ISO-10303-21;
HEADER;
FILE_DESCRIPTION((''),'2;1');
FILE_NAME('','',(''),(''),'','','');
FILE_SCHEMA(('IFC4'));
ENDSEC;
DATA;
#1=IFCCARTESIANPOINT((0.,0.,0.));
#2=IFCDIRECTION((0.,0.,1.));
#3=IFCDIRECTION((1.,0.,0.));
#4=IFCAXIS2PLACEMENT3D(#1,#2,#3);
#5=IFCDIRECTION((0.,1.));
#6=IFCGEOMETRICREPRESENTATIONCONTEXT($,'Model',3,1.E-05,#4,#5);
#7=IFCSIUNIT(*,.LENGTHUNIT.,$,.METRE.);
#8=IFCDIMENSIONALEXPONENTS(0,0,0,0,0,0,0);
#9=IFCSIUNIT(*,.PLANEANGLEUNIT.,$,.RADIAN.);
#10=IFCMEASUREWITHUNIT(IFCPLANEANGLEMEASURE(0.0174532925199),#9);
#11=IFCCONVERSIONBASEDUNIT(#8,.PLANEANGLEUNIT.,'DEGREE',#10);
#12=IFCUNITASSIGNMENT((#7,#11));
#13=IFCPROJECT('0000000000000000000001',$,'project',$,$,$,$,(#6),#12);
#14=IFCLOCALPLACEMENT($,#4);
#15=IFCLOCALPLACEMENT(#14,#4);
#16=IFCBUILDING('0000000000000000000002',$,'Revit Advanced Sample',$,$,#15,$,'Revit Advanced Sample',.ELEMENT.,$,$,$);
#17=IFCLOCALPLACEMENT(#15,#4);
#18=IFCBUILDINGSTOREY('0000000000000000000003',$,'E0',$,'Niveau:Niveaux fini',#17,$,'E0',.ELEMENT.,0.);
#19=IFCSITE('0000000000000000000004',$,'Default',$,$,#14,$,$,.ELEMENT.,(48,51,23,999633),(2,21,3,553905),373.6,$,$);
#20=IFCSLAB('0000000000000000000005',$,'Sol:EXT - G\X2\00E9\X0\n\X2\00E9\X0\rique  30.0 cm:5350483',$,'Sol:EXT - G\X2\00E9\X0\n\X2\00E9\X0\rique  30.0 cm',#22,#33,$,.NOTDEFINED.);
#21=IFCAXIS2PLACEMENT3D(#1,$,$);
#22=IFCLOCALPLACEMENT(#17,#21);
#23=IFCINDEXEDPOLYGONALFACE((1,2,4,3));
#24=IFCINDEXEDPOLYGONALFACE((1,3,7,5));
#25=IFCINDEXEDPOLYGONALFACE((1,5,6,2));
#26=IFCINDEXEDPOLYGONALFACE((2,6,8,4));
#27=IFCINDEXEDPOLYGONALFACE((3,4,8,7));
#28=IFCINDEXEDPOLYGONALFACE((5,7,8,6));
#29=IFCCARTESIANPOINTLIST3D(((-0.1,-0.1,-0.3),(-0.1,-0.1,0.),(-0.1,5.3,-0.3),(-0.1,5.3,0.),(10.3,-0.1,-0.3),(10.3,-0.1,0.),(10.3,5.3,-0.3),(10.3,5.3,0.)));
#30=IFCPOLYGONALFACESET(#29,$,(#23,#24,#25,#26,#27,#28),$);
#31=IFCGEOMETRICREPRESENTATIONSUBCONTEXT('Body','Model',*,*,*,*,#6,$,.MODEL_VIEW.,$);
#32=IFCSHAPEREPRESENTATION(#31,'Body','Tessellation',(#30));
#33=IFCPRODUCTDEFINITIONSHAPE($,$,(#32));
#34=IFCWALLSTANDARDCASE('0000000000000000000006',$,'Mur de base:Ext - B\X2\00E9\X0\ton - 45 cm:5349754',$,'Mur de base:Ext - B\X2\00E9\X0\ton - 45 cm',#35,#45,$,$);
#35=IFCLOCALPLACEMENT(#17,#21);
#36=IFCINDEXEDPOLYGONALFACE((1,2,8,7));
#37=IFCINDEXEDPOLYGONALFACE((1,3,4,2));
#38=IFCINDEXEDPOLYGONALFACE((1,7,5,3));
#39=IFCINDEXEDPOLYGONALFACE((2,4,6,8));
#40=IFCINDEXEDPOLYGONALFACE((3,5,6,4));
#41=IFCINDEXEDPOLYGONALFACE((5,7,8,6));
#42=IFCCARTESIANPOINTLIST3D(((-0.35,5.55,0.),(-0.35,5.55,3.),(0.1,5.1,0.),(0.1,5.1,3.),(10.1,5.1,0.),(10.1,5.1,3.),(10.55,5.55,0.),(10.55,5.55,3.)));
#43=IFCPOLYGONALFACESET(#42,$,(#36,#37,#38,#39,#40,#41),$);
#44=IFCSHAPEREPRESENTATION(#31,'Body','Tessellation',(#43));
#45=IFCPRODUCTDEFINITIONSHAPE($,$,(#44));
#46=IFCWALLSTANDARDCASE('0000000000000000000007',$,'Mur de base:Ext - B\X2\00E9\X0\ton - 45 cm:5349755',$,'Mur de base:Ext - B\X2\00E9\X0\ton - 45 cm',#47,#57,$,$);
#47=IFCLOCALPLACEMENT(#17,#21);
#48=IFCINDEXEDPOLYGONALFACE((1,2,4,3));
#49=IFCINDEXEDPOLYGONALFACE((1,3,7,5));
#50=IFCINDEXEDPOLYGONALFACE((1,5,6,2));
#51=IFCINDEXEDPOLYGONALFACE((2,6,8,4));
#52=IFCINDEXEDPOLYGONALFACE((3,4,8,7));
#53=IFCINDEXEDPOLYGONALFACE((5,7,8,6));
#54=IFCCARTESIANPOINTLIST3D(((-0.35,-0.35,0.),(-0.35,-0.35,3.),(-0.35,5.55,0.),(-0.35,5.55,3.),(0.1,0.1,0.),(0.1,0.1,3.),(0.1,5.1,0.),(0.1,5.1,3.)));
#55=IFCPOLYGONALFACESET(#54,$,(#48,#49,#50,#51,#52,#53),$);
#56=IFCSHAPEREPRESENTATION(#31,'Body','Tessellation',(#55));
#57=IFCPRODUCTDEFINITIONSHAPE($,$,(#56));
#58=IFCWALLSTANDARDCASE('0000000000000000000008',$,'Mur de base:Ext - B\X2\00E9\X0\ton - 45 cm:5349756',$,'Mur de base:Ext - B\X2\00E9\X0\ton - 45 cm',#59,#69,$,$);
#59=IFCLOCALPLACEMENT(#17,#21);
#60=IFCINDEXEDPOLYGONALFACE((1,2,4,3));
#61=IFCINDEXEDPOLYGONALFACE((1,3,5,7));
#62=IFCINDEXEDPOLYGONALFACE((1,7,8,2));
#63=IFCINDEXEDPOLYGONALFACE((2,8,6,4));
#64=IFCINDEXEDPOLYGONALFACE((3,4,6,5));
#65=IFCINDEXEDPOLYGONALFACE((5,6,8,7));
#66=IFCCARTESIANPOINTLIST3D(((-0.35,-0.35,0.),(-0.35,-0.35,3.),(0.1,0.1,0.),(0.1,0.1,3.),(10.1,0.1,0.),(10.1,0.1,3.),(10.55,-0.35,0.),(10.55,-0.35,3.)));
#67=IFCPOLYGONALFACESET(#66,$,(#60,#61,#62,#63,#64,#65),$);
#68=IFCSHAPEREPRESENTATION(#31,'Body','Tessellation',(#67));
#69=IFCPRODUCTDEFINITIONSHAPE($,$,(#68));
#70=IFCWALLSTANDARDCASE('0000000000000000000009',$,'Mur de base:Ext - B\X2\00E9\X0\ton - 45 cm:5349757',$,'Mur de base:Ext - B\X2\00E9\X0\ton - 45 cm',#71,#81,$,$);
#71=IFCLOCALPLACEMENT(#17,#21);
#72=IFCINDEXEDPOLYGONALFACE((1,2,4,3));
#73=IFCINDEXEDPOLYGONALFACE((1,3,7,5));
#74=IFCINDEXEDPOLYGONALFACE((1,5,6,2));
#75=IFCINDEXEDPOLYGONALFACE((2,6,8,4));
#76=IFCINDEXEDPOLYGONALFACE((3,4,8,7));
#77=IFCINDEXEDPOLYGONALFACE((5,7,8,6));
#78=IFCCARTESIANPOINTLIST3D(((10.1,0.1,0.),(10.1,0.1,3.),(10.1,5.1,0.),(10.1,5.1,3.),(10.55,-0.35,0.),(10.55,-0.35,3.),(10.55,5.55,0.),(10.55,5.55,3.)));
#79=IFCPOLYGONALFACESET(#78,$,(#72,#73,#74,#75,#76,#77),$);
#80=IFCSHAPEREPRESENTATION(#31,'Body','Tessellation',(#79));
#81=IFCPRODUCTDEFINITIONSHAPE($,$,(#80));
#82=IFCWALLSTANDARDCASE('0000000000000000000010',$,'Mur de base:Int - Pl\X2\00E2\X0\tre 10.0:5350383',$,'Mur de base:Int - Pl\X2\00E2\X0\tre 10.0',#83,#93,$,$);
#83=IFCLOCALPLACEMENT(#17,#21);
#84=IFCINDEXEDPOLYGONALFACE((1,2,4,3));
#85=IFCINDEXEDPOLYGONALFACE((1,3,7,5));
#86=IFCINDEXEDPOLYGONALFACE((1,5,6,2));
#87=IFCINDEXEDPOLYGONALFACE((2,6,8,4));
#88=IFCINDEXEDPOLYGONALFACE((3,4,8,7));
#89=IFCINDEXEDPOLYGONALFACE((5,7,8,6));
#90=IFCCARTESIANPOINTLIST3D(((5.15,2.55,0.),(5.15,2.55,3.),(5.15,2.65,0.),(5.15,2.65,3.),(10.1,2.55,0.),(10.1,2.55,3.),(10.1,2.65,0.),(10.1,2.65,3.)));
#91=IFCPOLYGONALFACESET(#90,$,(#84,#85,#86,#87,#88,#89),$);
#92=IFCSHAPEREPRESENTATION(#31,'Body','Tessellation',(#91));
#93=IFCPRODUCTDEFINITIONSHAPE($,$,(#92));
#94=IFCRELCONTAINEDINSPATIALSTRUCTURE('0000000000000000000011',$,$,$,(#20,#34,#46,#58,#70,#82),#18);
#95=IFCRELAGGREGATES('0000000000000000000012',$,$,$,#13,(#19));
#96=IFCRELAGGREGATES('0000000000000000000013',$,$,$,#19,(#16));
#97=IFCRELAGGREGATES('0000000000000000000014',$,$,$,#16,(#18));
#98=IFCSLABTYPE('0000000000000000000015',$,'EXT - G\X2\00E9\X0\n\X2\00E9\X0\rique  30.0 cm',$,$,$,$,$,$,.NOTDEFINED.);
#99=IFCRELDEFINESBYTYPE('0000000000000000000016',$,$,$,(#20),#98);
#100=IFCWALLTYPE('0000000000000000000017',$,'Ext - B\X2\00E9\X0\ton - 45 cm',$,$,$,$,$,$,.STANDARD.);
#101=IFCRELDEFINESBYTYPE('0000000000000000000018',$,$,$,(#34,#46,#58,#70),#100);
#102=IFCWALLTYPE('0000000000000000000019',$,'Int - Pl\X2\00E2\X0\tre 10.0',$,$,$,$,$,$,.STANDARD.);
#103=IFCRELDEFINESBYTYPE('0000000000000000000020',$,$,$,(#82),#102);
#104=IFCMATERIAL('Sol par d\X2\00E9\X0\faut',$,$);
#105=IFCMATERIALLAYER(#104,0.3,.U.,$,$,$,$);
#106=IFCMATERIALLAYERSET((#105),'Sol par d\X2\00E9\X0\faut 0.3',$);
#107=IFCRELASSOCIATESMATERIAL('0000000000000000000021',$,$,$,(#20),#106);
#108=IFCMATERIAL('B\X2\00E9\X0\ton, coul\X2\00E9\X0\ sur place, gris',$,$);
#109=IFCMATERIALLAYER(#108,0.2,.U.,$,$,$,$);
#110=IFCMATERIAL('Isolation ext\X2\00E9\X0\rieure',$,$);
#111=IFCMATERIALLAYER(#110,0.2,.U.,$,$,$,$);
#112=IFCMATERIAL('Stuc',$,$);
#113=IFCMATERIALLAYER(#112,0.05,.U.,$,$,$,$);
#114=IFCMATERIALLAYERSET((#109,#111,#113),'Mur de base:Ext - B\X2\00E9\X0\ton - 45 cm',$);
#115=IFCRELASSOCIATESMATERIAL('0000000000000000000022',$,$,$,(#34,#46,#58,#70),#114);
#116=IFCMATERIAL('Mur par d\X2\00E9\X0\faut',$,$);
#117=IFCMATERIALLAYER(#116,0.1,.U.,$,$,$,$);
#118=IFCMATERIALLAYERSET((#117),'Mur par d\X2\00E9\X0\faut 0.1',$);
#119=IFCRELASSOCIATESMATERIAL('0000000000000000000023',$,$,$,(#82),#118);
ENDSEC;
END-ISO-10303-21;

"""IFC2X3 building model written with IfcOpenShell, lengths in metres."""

from ifc_helpers import new_model, entity, si_unit, converted_unit, direction, frame, origin_with_axes, place, context, subcontext, project, spatial, polyline, outline, extrude, material, layer, layer_set, layer_usage, type_object, element, save


model = new_model("IFC2X3")

# Units and contexts
model_context = context("Model", 3, precision=1e-05, world=origin_with_axes(), true_north=direction((0.0, 1.0)))
body_context = subcontext(model_context, "Body", "Model", "MODEL_VIEW")
ifc_project = project(units=[si_unit("LENGTHUNIT", "METRE"), converted_unit("PLANEANGLEUNIT", "DEGREE", entity("IfcPlaneAngleMeasure", 0.0174532925199), si_unit("PLANEANGLEUNIT", "RADIAN"), dimensions=[0, 0, 0, 0, 0, 0, 0])], contexts=[model_context])

# Site, building, storey
site_placement = place(None, origin_with_axes())
site = spatial("IfcSite", under=ifc_project, at=site_placement, Name="Default", CompositionType="ELEMENT", RefLatitude=(48, 51, 23, 999633), RefLongitude=(2, 21, 3, 553905), RefElevation=373.6)
building_placement = place(site_placement, origin_with_axes())
building = spatial("IfcBuilding", under=site, at=building_placement, Name="Revit Advanced Sample", LongName="Revit Advanced Sample", CompositionType="ELEMENT")
storey_placement = place(building_placement, origin_with_axes())
storey = spatial("IfcBuildingStorey", under=building, at=storey_placement, Name="E0", ObjectType="Niveau:Niveaux fini", LongName="E0", CompositionType="ELEMENT", Elevation=0.0)

# Slab
ifc_material_1 = material(Name="Sol par défaut")
ifc_layer_1 = layer(ifc_material_1, 0.3, ventilated="UNKNOWN")
ifc_layer_set_1 = layer_set([ifc_layer_1], Name="Sol par défaut 0.3")
ifc_layer_usage_1 = layer_usage(ifc_layer_set_1, "AXIS3", "NEGATIVE", 0.3)
slab_type = type_object("IfcSlabType", Name="EXT - Générique  30.0 cm", PredefinedType="NOTDEFINED")
slab_placement = place(storey_placement, frame((-0.1, 5.3, 0.0), z_axis=(0.0, 0.0, 1.0), x_axis=(1.0, 0.0, 0.0)))
element("IfcSlab", 1, at=slab_placement, inside=storey, type_object=slab_type, material=ifc_layer_usage_1, Name="Sol:EXT - Générique  30.0 cm:5350483", ObjectType="Sol:EXT - Générique  30.0 cm", PredefinedType="NOTDEFINED", context=body_context, shape_type="SweptSolid", body=[
    extrude(outline(polyline([(0.0, 0.0), (0.0, -5.4), (10.4, -5.4), (10.4, 0.0), (0.0, 0.0)])), frame((0.0, 0.0, -0.3), z_axis=(0.0, 0.0, 1.0), x_axis=(1.0, 0.0, 0.0)), (0.0, 0.0, 1.0), 0.3),
])

# Walls
ifc_material_2 = material(Name="Béton, coulé sur place, gris")
ifc_layer_2 = layer(ifc_material_2, 0.2, ventilated="UNKNOWN")
ifc_material_3 = material(Name="Isolation extérieure")
ifc_layer_3 = layer(ifc_material_3, 0.2, ventilated="UNKNOWN")
ifc_material_4 = material(Name="Stuc")
ifc_layer_4 = layer(ifc_material_4, 0.05, ventilated="UNKNOWN")
ifc_layer_set_2 = layer_set([ifc_layer_2, ifc_layer_3, ifc_layer_4], Name="Mur de base:Ext - Béton - 45 cm")
ifc_layer_usage_2 = layer_usage(ifc_layer_set_2, "AXIS2", "POSITIVE", -0.225)
wall_type_1 = type_object("IfcWallType", Name="Ext - Béton - 45 cm", PredefinedType="STANDARD")
wall_1_placement = place(storey_placement, frame((-0.125, 5.325, 0.0), z_axis=(0.0, 0.0, 1.0), x_axis=(1.0, 0.0, 0.0)))
element("IfcWallStandardCase", 2, at=wall_1_placement, inside=storey, type_object=wall_type_1, material=ifc_layer_usage_2, Name="Mur de base:Ext - Béton - 45 cm:5349754", ObjectType="Mur de base:Ext - Béton - 45 cm", context=body_context, shape_type="SweptSolid", body=[
    extrude(outline(polyline([(0.225, -0.225), (10.225, -0.225), (10.675, 0.225), (-0.225, 0.225), (0.225, -0.225)])), origin_with_axes(), (0.0, 0.0, 1.0), 3.0),
])
ifc_layer_usage_3 = layer_usage(ifc_layer_set_2, "AXIS2", "POSITIVE", -0.225)
wall_2_placement = place(storey_placement, frame((-0.125, -0.125, 0.0), z_axis=(0.0, 0.0, 1.0), x_axis=(0.0, 1.0, 0.0)))
element("IfcWallStandardCase", 3, at=wall_2_placement, inside=storey, type_object=wall_type_1, material=ifc_layer_usage_3, Name="Mur de base:Ext - Béton - 45 cm:5349755", ObjectType="Mur de base:Ext - Béton - 45 cm", context=body_context, shape_type="SweptSolid", body=[
    extrude(outline(polyline([(0.225, -0.225), (5.225, -0.225), (5.675, 0.225), (-0.225, 0.225), (0.225, -0.225)])), origin_with_axes(), (0.0, 0.0, 1.0), 3.0),
])
ifc_layer_usage_4 = layer_usage(ifc_layer_set_2, "AXIS2", "POSITIVE", -0.225)
wall_3_placement = place(storey_placement, frame((10.325, -0.125, 0.0), z_axis=(0.0, 0.0, 1.0), x_axis=(-1.0, 0.0, 0.0)))
element("IfcWallStandardCase", 4, at=wall_3_placement, inside=storey, type_object=wall_type_1, material=ifc_layer_usage_4, Name="Mur de base:Ext - Béton - 45 cm:5349756", ObjectType="Mur de base:Ext - Béton - 45 cm", context=body_context, shape_type="SweptSolid", body=[
    extrude(outline(polyline([(0.225, -0.225), (10.225, -0.225), (10.675, 0.225), (-0.225, 0.225), (0.225, -0.225)])), origin_with_axes(), (0.0, 0.0, 1.0), 3.0),
])
ifc_layer_usage_5 = layer_usage(ifc_layer_set_2, "AXIS2", "POSITIVE", -0.225)
wall_4_placement = place(storey_placement, frame((10.325, 5.325, 0.0), z_axis=(0.0, 0.0, 1.0), x_axis=(0.0, -1.0, 0.0)))
element("IfcWallStandardCase", 5, at=wall_4_placement, inside=storey, type_object=wall_type_1, material=ifc_layer_usage_5, Name="Mur de base:Ext - Béton - 45 cm:5349757", ObjectType="Mur de base:Ext - Béton - 45 cm", context=body_context, shape_type="SweptSolid", body=[
    extrude(outline(polyline([(0.225, -0.225), (5.225, -0.225), (5.675, 0.225), (-0.225, 0.225), (0.225, -0.225)])), origin_with_axes(), (0.0, 0.0, 1.0), 3.0),
])
ifc_material_5 = material(Name="Mur par défaut")
ifc_layer_5 = layer(ifc_material_5, 0.1, ventilated="UNKNOWN")
ifc_layer_set_3 = layer_set([ifc_layer_5], Name="Mur par défaut 0.1")
wall_type_2 = type_object("IfcWallType", Name="Int - Plâtre 10.0", PredefinedType="STANDARD")
ifc_layer_usage_6 = layer_usage(ifc_layer_set_3, "AXIS2", "POSITIVE", -0.05)
wall_5_placement = place(storey_placement, frame((5.1, 2.6, 0.0), z_axis=(0.0, 0.0, 1.0), x_axis=(1.0, 0.0, 0.0)))
element("IfcWallStandardCase", 6, at=wall_5_placement, inside=storey, type_object=wall_type_2, material=ifc_layer_usage_6, Name="Mur de base:Int - Plâtre 10.0:5350383", ObjectType="Mur de base:Int - Plâtre 10.0", context=body_context, shape_type="SweptSolid", body=[
    extrude(outline(polyline([(0.05, -0.05), (5.0, -0.05), (5.0, 0.05), (0.05, 0.05), (0.05, -0.05)])), origin_with_axes(), (0.0, 0.0, 1.0), 3.0),
])

save(model, "model.ifc")
